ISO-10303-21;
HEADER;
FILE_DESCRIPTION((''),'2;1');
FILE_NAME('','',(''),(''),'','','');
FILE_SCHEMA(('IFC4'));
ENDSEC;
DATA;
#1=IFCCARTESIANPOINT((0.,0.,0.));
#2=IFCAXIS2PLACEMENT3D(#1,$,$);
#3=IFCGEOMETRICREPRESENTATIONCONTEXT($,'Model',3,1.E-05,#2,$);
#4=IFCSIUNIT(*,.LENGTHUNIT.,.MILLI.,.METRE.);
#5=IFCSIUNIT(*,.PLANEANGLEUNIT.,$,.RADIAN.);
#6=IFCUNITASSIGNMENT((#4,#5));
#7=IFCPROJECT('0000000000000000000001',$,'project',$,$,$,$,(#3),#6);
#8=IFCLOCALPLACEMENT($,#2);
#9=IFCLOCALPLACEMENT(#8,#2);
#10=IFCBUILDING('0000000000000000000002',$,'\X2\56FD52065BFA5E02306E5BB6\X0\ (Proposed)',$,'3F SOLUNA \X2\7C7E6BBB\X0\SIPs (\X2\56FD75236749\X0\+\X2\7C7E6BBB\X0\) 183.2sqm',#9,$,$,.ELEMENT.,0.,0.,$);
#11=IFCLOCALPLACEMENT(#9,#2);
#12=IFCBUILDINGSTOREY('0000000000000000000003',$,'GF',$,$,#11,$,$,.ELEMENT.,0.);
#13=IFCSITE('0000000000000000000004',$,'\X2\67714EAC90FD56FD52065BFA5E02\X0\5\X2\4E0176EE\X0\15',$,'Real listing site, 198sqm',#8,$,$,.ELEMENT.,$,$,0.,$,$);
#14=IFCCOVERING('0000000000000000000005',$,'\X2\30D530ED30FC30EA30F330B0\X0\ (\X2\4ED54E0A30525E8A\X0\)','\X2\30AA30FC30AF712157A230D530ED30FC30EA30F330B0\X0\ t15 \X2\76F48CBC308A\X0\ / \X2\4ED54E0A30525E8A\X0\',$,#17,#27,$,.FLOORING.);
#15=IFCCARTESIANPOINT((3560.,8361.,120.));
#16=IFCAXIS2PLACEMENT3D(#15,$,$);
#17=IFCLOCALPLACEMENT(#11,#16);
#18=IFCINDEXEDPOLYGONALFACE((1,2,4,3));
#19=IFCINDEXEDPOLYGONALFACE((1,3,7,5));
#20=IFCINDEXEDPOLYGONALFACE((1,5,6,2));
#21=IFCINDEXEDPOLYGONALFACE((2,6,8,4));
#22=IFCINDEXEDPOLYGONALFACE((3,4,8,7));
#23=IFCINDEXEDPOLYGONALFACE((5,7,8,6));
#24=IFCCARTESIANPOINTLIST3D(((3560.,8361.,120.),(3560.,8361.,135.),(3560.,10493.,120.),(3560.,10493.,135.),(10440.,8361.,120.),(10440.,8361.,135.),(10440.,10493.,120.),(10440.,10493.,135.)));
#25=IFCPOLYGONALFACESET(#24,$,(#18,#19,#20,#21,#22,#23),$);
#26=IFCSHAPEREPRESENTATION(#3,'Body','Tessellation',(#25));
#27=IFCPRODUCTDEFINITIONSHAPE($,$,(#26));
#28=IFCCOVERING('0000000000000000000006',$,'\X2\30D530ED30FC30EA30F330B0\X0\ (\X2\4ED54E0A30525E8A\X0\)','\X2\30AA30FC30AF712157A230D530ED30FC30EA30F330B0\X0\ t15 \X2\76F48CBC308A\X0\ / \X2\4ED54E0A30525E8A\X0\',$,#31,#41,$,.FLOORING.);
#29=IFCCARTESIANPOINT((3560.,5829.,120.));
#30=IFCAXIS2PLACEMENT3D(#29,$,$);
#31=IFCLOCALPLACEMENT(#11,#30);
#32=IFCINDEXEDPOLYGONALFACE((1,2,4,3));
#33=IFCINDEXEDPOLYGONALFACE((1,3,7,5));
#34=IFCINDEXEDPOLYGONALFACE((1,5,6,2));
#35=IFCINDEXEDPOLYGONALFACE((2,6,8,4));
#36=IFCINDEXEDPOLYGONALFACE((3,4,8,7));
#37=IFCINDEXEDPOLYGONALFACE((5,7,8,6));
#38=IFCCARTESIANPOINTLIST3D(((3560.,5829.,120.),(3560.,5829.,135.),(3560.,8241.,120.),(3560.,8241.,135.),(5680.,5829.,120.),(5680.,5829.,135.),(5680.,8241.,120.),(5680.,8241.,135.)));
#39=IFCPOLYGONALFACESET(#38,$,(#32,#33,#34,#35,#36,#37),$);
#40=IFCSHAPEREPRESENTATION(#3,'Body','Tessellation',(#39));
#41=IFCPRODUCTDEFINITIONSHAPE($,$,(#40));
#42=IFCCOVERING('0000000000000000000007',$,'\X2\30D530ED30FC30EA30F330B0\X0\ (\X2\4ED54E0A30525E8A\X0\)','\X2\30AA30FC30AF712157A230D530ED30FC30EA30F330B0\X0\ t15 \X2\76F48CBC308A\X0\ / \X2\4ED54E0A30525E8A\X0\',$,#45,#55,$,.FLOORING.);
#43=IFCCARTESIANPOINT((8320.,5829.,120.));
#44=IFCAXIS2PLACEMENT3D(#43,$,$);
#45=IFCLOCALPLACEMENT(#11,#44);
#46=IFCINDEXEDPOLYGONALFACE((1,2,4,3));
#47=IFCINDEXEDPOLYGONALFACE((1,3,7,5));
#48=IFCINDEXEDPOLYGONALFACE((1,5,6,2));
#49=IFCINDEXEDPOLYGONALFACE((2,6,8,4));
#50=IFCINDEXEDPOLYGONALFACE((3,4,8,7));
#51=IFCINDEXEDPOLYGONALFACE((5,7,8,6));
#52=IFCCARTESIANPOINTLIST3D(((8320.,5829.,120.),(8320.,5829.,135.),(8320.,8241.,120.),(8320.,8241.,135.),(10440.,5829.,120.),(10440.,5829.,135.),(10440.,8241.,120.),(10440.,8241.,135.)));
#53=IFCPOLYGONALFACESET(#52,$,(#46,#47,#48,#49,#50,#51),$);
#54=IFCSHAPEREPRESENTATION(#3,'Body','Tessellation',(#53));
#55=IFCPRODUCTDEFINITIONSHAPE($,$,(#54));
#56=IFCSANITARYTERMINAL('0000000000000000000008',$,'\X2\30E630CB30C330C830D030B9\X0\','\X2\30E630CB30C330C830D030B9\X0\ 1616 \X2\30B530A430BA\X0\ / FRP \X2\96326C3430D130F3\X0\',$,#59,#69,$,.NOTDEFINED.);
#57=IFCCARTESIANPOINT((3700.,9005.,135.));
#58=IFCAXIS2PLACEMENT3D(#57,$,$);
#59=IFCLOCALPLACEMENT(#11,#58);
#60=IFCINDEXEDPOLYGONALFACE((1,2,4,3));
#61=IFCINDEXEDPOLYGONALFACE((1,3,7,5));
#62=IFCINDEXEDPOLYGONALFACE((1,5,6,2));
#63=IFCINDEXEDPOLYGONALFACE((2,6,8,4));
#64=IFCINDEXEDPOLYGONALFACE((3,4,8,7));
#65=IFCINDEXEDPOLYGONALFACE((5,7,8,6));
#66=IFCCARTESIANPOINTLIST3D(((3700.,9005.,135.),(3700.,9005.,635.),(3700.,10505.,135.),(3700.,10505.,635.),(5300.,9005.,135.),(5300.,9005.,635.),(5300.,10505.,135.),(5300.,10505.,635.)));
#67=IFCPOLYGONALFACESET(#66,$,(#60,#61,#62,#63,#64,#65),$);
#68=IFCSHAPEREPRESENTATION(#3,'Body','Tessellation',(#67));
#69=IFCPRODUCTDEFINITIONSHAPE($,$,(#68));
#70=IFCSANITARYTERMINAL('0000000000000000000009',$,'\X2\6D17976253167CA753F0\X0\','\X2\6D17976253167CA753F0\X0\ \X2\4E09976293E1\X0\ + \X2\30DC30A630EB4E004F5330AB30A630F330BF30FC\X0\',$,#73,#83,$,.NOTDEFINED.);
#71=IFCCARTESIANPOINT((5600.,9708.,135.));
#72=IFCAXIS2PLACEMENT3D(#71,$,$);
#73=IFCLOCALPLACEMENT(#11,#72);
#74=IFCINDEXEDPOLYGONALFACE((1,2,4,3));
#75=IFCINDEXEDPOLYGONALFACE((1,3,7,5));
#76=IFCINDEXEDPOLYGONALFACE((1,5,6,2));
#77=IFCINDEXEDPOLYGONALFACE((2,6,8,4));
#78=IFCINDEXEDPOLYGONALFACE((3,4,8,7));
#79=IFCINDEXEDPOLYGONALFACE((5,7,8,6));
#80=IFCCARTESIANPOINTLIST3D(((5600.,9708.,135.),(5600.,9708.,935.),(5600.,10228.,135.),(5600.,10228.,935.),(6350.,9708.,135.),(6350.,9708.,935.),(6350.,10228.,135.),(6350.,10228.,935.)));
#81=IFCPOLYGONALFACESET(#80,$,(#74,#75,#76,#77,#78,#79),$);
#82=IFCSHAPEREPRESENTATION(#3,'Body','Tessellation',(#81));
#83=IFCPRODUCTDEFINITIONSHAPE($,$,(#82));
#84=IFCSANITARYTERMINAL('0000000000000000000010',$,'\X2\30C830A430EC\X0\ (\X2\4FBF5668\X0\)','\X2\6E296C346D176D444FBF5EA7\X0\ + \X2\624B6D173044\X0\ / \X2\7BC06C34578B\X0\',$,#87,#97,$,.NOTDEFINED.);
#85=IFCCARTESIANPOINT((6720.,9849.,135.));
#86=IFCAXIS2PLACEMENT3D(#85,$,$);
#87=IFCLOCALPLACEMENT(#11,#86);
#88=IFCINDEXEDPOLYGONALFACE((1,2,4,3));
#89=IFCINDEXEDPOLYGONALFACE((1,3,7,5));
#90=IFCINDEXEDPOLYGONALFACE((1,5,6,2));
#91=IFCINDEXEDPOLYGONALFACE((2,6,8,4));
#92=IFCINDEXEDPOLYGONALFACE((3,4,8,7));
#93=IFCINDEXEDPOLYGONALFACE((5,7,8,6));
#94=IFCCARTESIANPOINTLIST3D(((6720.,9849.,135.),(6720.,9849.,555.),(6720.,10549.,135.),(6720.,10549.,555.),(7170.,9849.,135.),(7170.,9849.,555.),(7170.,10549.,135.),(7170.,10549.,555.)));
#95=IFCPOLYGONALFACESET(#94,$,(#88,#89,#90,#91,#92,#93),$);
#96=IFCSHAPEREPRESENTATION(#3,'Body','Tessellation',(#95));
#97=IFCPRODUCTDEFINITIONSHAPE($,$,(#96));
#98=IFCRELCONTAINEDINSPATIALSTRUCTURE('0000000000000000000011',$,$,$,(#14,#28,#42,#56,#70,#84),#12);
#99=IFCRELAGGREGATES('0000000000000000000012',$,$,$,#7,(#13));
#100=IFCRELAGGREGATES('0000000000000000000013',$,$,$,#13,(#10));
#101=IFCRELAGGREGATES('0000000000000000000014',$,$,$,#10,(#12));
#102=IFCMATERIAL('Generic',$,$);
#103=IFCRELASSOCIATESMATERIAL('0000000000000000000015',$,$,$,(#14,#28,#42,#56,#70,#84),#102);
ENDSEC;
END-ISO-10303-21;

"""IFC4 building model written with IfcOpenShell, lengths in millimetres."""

from ifc_helpers import new_model, si_unit, frame, frame_2d, origin, place, context, project, spatial, rectangle, extrude, material, element, save


model = new_model("IFC4")

# Units and contexts
model_context = context("Model", 3, precision=1e-05, world=origin())
ifc_project = project(units=[si_unit("LENGTHUNIT", "METRE", prefix="MILLI"), si_unit("PLANEANGLEUNIT", "RADIAN")], contexts=[model_context])

# Site, building, storey
site_placement = place(None, origin())
site = spatial("IfcSite", under=ifc_project, at=site_placement, Name="東京都国分寺市5丁目15", ObjectType="Real listing site, 198sqm", CompositionType="ELEMENT", RefElevation=0.0)
building_placement = place(site_placement, origin())
building = spatial("IfcBuilding", under=site, at=building_placement, Name="国分寺市の家 (Proposed)", ObjectType="3F SOLUNA 籾殻SIPs (国産杉+籾殻) 183.2sqm", CompositionType="ELEMENT", ElevationOfRefHeight=0.0, ElevationOfTerrain=0.0)
storey_placement = place(building_placement, origin())
storey = spatial("IfcBuildingStorey", under=building, at=storey_placement, Name="GF", CompositionType="ELEMENT", Elevation=0.0)

# Coverings
ifc_material_1 = material(Name="Generic")
covering_1_placement = place(storey_placement, frame((3560.0, 8361.0, 120.0)))
element("IfcCovering", 1, at=covering_1_placement, inside=storey, material=ifc_material_1, Name="フローリング (仕上げ床)", Description="オーク無垢フローリング t15 直貼り / 仕上げ床", PredefinedType="FLOORING", context=model_context, shape_type="SweptSolid", body=[
    extrude(rectangle(XDim=6880.0, YDim=2132.0, at=frame_2d((3440.0, 1066.0))), frame((3560.0, 8361.0, 120.0)), (0.0, 0.0, 1.0), 15.0),
])
covering_2_placement = place(storey_placement, frame((3560.0, 5829.0, 120.0)))
element("IfcCovering", 2, at=covering_2_placement, inside=storey, material=ifc_material_1, Name="フローリング (仕上げ床)", Description="オーク無垢フローリング t15 直貼り / 仕上げ床", PredefinedType="FLOORING", context=model_context, shape_type="SweptSolid", body=[
    extrude(rectangle(XDim=2120.0, YDim=2412.0, at=frame_2d((1060.0, 1206.0))), frame((3560.0, 5829.0, 120.0)), (0.0, 0.0, 1.0), 15.0),
])
covering_3_placement = place(storey_placement, frame((8320.0, 5829.0, 120.0)))
element("IfcCovering", 3, at=covering_3_placement, inside=storey, material=ifc_material_1, Name="フローリング (仕上げ床)", Description="オーク無垢フローリング t15 直貼り / 仕上げ床", PredefinedType="FLOORING", context=model_context, shape_type="SweptSolid", body=[
    extrude(rectangle(XDim=2120.0, YDim=2412.0, at=frame_2d((1060.0, 1206.0))), frame((8320.0, 5829.0, 120.0)), (0.0, 0.0, 1.0), 15.0),
])

# Sanitary terminals
sanitary_terminal_1_placement = place(storey_placement, frame((3700.0, 9005.0, 135.0)))
element("IfcSanitaryTerminal", 4, at=sanitary_terminal_1_placement, inside=storey, material=ifc_material_1, Name="ユニットバス", Description="ユニットバス 1616 サイズ / FRP 防水パン", PredefinedType="NOTDEFINED", context=model_context, shape_type="SweptSolid", body=[
    extrude(rectangle(XDim=1600.0, YDim=1500.0, at=frame_2d((800.0, 750.0))), frame((3700.0, 9005.0, 135.0)), (0.0, 0.0, 1.0), 500.0),
])
sanitary_terminal_2_placement = place(storey_placement, frame((5600.0, 9708.0, 135.0)))
element("IfcSanitaryTerminal", 5, at=sanitary_terminal_2_placement, inside=storey, material=ifc_material_1, Name="洗面化粧台", Description="洗面化粧台 三面鏡 + ボウル一体カウンター", PredefinedType="NOTDEFINED", context=model_context, shape_type="SweptSolid", body=[
    extrude(rectangle(XDim=750.0, YDim=520.0, at=frame_2d((375.0, 260.0))), frame((5600.0, 9708.0, 135.0)), (0.0, 0.0, 1.0), 800.0),
])
sanitary_terminal_3_placement = place(storey_placement, frame((6720.0, 9849.0, 135.0)))
element("IfcSanitaryTerminal", 6, at=sanitary_terminal_3_placement, inside=storey, material=ifc_material_1, Name="トイレ (便器)", Description="温水洗浄便座 + 手洗い / 節水型", PredefinedType="NOTDEFINED", context=model_context, shape_type="SweptSolid", body=[
    extrude(rectangle(XDim=450.0, YDim=700.0, at=frame_2d((225.0, 350.0))), frame((6720.0, 9849.0, 135.0)), (0.0, 0.0, 1.0), 420.0),
])

save(model, "model.ifc")
